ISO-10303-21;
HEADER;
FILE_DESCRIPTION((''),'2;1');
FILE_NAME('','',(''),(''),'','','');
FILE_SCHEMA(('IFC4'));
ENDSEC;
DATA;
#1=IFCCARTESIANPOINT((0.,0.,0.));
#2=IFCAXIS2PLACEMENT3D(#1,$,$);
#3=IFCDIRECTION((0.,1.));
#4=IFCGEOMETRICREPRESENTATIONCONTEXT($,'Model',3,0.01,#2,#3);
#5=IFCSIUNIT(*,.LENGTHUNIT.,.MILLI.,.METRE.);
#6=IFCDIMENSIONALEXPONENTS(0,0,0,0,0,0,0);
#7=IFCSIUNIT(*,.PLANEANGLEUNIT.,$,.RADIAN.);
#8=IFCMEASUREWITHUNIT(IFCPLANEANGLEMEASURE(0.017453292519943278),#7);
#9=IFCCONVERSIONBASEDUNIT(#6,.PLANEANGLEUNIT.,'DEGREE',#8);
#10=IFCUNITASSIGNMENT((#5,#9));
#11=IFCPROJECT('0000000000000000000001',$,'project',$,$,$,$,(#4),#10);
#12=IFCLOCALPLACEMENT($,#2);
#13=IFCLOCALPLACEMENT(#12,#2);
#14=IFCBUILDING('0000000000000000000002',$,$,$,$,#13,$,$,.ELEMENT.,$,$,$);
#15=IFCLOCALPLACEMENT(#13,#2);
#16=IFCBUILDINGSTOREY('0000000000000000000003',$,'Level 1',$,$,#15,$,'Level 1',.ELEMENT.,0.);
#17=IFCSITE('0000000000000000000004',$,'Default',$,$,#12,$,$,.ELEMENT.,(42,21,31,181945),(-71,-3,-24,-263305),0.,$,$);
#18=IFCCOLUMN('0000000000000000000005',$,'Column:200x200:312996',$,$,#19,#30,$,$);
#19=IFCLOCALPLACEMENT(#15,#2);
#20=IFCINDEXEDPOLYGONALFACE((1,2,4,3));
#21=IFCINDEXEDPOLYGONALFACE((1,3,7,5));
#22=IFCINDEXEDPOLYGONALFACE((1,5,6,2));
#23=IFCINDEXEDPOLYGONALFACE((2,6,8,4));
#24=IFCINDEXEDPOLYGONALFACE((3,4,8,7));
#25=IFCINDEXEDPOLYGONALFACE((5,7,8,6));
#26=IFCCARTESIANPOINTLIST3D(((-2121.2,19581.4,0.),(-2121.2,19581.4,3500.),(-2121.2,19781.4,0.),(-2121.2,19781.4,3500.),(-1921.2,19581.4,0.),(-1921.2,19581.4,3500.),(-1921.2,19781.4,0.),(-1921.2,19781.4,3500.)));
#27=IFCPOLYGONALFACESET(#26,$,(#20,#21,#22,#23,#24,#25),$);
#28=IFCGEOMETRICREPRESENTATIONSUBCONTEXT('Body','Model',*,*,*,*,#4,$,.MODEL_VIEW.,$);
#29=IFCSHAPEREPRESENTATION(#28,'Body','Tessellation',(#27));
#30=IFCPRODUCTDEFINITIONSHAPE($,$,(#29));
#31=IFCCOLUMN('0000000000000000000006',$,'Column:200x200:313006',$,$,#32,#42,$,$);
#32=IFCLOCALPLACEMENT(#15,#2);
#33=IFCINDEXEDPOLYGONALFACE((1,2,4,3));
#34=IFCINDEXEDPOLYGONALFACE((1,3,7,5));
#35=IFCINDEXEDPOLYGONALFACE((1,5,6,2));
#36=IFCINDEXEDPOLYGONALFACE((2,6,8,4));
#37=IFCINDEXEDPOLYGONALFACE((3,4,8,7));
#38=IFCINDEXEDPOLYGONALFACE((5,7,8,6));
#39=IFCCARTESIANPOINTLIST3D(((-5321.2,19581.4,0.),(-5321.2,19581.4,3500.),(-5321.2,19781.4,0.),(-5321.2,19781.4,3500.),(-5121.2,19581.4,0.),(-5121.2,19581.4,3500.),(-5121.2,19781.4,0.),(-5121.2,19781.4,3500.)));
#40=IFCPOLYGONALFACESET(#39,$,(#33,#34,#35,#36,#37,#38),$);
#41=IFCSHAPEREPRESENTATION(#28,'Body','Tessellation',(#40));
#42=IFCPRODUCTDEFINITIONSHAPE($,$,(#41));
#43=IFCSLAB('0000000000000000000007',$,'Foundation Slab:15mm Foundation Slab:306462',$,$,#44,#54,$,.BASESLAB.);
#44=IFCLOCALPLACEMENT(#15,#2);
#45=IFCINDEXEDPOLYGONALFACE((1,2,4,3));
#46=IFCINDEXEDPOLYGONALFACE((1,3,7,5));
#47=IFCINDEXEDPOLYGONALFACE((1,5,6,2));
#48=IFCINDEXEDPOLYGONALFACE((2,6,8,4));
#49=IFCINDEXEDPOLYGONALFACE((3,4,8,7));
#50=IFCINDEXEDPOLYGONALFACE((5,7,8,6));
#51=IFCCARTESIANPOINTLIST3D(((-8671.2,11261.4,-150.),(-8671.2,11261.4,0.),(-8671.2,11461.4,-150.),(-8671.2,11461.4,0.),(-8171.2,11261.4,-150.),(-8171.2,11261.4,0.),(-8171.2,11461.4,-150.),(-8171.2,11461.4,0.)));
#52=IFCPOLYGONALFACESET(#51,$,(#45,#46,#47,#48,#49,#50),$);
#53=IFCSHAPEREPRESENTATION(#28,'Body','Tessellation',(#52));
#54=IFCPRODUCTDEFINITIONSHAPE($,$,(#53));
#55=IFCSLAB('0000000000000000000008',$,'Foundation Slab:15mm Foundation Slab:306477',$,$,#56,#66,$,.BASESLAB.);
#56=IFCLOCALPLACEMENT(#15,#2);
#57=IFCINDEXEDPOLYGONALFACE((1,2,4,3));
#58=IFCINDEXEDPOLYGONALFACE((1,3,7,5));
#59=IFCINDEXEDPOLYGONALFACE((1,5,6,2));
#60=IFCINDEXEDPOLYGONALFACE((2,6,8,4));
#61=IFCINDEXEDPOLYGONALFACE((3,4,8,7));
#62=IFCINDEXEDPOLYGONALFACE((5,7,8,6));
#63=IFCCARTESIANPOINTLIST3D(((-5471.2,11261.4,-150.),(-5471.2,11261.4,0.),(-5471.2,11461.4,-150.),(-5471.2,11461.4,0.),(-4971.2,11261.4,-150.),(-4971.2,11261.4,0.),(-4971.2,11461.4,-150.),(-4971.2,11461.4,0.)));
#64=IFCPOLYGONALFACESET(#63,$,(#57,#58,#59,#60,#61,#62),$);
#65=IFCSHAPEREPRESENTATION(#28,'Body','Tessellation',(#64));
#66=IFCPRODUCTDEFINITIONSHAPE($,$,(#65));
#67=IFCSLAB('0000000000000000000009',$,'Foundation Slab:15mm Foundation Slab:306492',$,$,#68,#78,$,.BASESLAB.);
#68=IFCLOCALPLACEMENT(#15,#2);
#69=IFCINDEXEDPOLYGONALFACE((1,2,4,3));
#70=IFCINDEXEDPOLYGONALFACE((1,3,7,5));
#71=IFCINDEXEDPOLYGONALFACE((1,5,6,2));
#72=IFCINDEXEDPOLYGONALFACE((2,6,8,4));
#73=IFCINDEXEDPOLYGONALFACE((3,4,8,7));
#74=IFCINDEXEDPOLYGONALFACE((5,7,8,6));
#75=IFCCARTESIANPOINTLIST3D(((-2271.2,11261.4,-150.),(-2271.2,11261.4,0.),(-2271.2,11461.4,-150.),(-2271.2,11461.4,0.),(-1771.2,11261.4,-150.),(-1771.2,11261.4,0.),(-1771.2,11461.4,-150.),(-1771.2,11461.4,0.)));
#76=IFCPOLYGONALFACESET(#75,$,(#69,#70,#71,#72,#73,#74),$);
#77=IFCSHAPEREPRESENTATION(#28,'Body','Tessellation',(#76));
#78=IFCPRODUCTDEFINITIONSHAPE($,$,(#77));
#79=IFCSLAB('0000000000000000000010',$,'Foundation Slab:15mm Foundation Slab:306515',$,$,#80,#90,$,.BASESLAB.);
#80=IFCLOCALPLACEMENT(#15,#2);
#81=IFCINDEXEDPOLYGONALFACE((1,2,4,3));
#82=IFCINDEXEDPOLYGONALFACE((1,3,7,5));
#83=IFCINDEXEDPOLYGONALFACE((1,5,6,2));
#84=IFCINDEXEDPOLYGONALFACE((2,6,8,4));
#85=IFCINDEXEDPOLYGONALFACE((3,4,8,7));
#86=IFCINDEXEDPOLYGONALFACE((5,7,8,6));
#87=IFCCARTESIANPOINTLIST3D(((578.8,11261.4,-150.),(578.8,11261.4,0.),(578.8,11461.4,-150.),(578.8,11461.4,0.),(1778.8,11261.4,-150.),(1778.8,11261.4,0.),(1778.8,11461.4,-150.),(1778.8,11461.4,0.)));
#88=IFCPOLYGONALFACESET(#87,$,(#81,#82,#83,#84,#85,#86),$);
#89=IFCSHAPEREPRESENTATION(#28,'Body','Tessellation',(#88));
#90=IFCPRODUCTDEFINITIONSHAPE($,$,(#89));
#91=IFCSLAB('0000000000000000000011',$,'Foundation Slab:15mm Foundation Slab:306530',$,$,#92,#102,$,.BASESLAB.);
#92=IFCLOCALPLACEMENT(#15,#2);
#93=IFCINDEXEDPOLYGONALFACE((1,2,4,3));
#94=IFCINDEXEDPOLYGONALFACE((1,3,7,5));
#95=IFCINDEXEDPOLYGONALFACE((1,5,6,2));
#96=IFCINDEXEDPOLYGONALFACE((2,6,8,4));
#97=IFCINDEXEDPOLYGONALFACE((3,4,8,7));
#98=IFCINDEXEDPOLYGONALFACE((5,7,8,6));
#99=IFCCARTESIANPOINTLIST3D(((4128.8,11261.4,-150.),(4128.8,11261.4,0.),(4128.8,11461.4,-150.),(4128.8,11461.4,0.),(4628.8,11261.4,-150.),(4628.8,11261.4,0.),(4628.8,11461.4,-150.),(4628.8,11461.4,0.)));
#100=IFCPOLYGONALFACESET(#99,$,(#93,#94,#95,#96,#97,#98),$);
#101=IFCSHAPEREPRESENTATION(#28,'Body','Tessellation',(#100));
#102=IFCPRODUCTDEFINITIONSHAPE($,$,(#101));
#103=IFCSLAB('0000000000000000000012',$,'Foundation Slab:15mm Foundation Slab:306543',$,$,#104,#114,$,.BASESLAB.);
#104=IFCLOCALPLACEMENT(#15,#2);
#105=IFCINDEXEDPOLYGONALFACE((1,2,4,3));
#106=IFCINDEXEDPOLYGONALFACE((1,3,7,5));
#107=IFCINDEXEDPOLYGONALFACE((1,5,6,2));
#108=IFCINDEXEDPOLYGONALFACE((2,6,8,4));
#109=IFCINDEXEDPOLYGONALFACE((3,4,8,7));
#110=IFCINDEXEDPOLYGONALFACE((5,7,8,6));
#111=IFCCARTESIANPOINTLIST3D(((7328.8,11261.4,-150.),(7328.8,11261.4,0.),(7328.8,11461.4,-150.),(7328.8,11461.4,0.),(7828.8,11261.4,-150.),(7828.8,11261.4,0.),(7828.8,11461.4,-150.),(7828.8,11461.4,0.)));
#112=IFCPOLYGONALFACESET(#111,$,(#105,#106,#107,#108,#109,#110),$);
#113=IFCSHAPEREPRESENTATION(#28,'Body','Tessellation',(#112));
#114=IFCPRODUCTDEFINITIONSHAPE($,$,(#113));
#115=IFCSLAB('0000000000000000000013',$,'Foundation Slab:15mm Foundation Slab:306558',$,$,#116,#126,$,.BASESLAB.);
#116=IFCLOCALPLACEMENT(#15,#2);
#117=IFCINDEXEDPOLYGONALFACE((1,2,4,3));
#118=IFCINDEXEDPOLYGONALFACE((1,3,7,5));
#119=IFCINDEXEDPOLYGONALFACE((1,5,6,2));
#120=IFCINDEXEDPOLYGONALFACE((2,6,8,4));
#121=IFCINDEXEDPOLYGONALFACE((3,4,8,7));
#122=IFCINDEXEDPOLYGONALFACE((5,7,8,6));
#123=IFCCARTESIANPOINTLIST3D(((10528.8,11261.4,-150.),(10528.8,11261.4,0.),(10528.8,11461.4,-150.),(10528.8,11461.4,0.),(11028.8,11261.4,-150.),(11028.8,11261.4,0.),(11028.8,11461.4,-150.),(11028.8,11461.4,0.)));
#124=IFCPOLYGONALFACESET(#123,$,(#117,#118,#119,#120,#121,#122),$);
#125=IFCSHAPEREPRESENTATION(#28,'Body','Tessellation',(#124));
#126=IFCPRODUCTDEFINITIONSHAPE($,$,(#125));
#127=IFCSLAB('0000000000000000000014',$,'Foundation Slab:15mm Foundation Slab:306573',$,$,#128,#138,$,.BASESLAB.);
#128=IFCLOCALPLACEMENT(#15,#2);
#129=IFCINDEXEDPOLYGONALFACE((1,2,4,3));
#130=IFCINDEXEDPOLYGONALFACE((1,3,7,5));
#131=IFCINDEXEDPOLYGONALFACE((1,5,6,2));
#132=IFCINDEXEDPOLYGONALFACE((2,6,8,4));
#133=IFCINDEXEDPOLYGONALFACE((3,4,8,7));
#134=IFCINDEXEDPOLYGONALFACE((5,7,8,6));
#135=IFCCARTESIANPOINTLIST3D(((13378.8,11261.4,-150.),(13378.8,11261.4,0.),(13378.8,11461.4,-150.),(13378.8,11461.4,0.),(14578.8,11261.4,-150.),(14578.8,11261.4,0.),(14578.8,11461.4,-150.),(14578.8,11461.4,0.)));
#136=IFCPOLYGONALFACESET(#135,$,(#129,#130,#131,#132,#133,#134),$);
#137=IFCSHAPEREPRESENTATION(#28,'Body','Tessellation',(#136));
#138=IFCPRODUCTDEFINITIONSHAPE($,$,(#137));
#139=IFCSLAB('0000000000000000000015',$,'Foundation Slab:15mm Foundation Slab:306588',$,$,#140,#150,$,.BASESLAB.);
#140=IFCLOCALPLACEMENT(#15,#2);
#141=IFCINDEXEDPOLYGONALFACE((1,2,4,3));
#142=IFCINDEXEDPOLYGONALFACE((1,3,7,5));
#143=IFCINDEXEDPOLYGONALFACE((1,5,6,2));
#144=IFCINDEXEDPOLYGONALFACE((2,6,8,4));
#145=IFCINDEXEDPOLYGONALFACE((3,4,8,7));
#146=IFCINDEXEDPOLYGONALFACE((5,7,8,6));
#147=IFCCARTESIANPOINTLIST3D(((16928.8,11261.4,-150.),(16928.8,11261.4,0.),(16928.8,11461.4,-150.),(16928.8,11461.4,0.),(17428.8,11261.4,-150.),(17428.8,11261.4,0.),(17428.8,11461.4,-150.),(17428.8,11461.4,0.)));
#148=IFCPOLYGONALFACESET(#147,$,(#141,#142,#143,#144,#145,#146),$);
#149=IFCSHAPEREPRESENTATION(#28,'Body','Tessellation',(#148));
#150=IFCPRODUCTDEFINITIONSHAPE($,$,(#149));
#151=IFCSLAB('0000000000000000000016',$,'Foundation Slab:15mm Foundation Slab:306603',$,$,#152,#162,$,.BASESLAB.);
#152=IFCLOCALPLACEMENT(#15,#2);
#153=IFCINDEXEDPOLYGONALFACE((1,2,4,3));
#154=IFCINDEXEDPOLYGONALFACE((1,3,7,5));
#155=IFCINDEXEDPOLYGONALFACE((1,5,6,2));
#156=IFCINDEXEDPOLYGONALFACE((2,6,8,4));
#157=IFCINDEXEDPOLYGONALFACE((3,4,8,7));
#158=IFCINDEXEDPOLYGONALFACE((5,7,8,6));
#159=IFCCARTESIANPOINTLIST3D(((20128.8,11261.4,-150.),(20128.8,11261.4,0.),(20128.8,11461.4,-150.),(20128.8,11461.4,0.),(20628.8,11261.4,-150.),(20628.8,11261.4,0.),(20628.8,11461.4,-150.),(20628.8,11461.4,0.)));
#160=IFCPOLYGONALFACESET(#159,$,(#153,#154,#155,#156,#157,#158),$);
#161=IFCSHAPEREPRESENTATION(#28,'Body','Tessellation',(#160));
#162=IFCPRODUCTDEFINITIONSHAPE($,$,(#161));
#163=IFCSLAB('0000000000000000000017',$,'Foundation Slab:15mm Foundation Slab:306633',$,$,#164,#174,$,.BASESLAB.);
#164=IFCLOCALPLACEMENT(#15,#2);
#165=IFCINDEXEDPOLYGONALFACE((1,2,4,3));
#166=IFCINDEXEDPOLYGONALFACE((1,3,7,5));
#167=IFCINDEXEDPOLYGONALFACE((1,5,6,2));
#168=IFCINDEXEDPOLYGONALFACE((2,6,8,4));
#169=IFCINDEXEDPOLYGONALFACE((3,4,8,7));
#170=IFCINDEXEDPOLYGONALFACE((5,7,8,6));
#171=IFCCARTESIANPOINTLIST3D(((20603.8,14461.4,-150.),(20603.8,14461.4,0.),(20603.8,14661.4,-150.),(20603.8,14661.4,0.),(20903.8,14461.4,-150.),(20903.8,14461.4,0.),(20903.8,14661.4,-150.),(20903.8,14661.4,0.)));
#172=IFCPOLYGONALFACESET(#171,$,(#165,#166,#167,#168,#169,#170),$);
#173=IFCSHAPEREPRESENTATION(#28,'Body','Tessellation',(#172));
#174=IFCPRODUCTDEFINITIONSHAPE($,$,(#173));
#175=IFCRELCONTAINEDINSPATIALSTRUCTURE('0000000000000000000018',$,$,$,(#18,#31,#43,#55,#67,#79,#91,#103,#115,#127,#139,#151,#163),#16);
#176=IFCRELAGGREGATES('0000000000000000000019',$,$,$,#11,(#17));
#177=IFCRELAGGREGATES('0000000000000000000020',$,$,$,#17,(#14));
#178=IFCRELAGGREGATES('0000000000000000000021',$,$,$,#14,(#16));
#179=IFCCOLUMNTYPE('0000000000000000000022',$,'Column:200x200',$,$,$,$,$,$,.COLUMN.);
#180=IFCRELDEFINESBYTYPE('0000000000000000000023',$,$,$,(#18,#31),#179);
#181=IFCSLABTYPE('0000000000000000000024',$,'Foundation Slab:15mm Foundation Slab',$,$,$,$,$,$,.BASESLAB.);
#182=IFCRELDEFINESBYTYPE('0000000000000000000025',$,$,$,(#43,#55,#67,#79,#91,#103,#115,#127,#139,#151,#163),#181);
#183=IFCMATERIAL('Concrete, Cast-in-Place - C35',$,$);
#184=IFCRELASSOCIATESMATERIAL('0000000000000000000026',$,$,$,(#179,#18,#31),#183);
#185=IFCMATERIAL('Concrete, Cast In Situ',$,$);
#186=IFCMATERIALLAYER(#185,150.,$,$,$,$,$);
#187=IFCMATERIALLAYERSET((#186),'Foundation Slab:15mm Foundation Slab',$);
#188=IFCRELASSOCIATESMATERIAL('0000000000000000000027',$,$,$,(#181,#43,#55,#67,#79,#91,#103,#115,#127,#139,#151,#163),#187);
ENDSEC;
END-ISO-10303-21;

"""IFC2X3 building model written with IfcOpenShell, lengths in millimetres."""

from ifc_helpers import new_model, entity, si_unit, converted_unit, direction, frame, frame_2d, origin, place, context, subcontext, project, spatial, rectangle, extrude, source, transform, mapped, material, layer, layer_set, layer_usage, type_object, type_shapes, element, save


model = new_model("IFC2X3")

# Units and contexts
model_context = context("Model", 3, precision=0.01, world=origin(), true_north=direction((0.0, 1.0)))
body_context = subcontext(model_context, "Body", "Model", "MODEL_VIEW")
ifc_project = project(units=[si_unit("LENGTHUNIT", "METRE", prefix="MILLI"), converted_unit("PLANEANGLEUNIT", "DEGREE", entity("IfcPlaneAngleMeasure", 0.017453292519943278), si_unit("PLANEANGLEUNIT", "RADIAN"), dimensions=[0, 0, 0, 0, 0, 0, 0])], contexts=[model_context])

# Site, building, storey
site_placement = place(None, origin())
site = spatial("IfcSite", under=ifc_project, at=site_placement, Name="Default", CompositionType="ELEMENT", RefLatitude=(42, 21, 31, 181945), RefLongitude=(-71, -3, -24, -263305), RefElevation=0.0)
building_placement = place(site_placement, origin())
building = spatial("IfcBuilding", under=site, at=building_placement, CompositionType="ELEMENT")
storey_placement = place(building_placement, origin())
storey = spatial("IfcBuildingStorey", under=building, at=storey_placement, Name="Level 1", LongName="Level 1", CompositionType="ELEMENT", Elevation=0.0)

# Columns
ifc_material_1 = material(Name="Concrete, Cast-in-Place - C35")
column_type_1 = type_object("IfcColumnType", Name="Column:200x200", PredefinedType="COLUMN", material=ifc_material_1)
shared_shape_1 = source(origin(), body_context, "Body", "SweptSolid", [
    extrude(rectangle(XDim=200.0, YDim=200.0, at=frame_2d((0.0, 0.0), x_axis=(1.0, 0.0))), frame((0.0, 0.0, 0.0), z_axis=(0.0, 0.0, 1.0), x_axis=(-1.0, 0.0, 0.0)), (0.0, 0.0, 1.0), 3500.0),
])
type_shapes(column_type_1, [shared_shape_1])
for number, where, name in (
    (1, (-2021.2, 19681.4, 0.0), "Column:200x200:312996"),
    (2, (-5221.2, 19681.4, 0.0), "Column:200x200:313006"),
):
    element("IfcColumn", number, at=place(storey_placement, frame(where)), inside=storey, type_object=column_type_1, material=ifc_material_1, Name=name, context=body_context, shape_type="MappedRepresentation", body=[
        mapped(shared_shape_1, transform((0.0, 0.0, 0.0), scale=1.0)),
    ])

# Slabs
ifc_material_2 = material(Name="Concrete, Cast In Situ")
ifc_layer_1 = layer(ifc_material_2, 150.0)
ifc_layer_set_1 = layer_set([ifc_layer_1], Name="Foundation Slab:15mm Foundation Slab")
ifc_layer_usage_1 = layer_usage(ifc_layer_set_1, "AXIS3", "POSITIVE", 0.0)
slab_type = type_object("IfcSlabType", Name="Foundation Slab:15mm Foundation Slab", PredefinedType="BASESLAB", material=ifc_layer_set_1)
slab_1_placement = place(storey_placement, origin())
element("IfcSlab", 3, at=slab_1_placement, inside=storey, type_object=slab_type, material=ifc_layer_usage_1, Name="Foundation Slab:15mm Foundation Slab:306462", PredefinedType="BASESLAB", context=body_context, shape_type="SweptSolid", body=[
    extrude(rectangle(XDim=200.0, YDim=500.0, at=frame_2d((0.0, 0.0), x_axis=(1.0, 0.0))), frame((-8421.2, 11361.4, 0.0), z_axis=(0.0, 0.0, -1.0), x_axis=(0.0, 1.0, 0.0)), (0.0, 0.0, 1.0), 150.0),
])
ifc_layer_usage_2 = layer_usage(ifc_layer_set_1, "AXIS3", "POSITIVE", 0.0)
slab_2_placement = place(storey_placement, origin())
element("IfcSlab", 4, at=slab_2_placement, inside=storey, type_object=slab_type, material=ifc_layer_usage_2, Name="Foundation Slab:15mm Foundation Slab:306477", PredefinedType="BASESLAB", context=body_context, shape_type="SweptSolid", body=[
    extrude(rectangle(XDim=200.0, YDim=500.0, at=frame_2d((0.0, 0.0), x_axis=(1.0, 0.0))), frame((-5221.2, 11361.4, 0.0), z_axis=(0.0, 0.0, -1.0), x_axis=(0.0, 1.0, 0.0)), (0.0, 0.0, 1.0), 150.0),
])
ifc_layer_usage_3 = layer_usage(ifc_layer_set_1, "AXIS3", "POSITIVE", 0.0)
slab_3_placement = place(storey_placement, origin())
element("IfcSlab", 5, at=slab_3_placement, inside=storey, type_object=slab_type, material=ifc_layer_usage_3, Name="Foundation Slab:15mm Foundation Slab:306492", PredefinedType="BASESLAB", context=body_context, shape_type="SweptSolid", body=[
    extrude(rectangle(XDim=200.0, YDim=500.0, at=frame_2d((0.0, 0.0), x_axis=(1.0, 0.0))), frame((-2021.2, 11361.4, 0.0), z_axis=(0.0, 0.0, -1.0), x_axis=(0.0, 1.0, 0.0)), (0.0, 0.0, 1.0), 150.0),
])
ifc_layer_usage_4 = layer_usage(ifc_layer_set_1, "AXIS3", "POSITIVE", 0.0)
slab_4_placement = place(storey_placement, origin())
element("IfcSlab", 6, at=slab_4_placement, inside=storey, type_object=slab_type, material=ifc_layer_usage_4, Name="Foundation Slab:15mm Foundation Slab:306515", PredefinedType="BASESLAB", context=body_context, shape_type="SweptSolid", body=[
    extrude(rectangle(XDim=200.0, YDim=1200.0, at=frame_2d((0.0, 0.0), x_axis=(1.0, 0.0))), frame((1178.8, 11361.4, 0.0), z_axis=(0.0, 0.0, -1.0), x_axis=(0.0, 1.0, 0.0)), (0.0, 0.0, 1.0), 150.0),
])
ifc_layer_usage_5 = layer_usage(ifc_layer_set_1, "AXIS3", "POSITIVE", 0.0)
slab_5_placement = place(storey_placement, origin())
element("IfcSlab", 7, at=slab_5_placement, inside=storey, type_object=slab_type, material=ifc_layer_usage_5, Name="Foundation Slab:15mm Foundation Slab:306530", PredefinedType="BASESLAB", context=body_context, shape_type="SweptSolid", body=[
    extrude(rectangle(XDim=200.0, YDim=500.0, at=frame_2d((0.0, 0.0), x_axis=(1.0, 0.0))), frame((4378.8, 11361.4, 0.0), z_axis=(0.0, 0.0, -1.0), x_axis=(0.0, 1.0, 0.0)), (0.0, 0.0, 1.0), 150.0),
])
ifc_layer_usage_6 = layer_usage(ifc_layer_set_1, "AXIS3", "POSITIVE", 0.0)
slab_6_placement = place(storey_placement, origin())
element("IfcSlab", 8, at=slab_6_placement, inside=storey, type_object=slab_type, material=ifc_layer_usage_6, Name="Foundation Slab:15mm Foundation Slab:306543", PredefinedType="BASESLAB", context=body_context, shape_type="SweptSolid", body=[
    extrude(rectangle(XDim=200.0, YDim=500.0, at=frame_2d((0.0, 0.0), x_axis=(1.0, 0.0))), frame((7578.8, 11361.4, 0.0), z_axis=(0.0, 0.0, -1.0), x_axis=(0.0, 1.0, 0.0)), (0.0, 0.0, 1.0), 150.0),
])
ifc_layer_usage_7 = layer_usage(ifc_layer_set_1, "AXIS3", "POSITIVE", 0.0)
slab_7_placement = place(storey_placement, origin())
element("IfcSlab", 9, at=slab_7_placement, inside=storey, type_object=slab_type, material=ifc_layer_usage_7, Name="Foundation Slab:15mm Foundation Slab:306558", PredefinedType="BASESLAB", context=body_context, shape_type="SweptSolid", body=[
    extrude(rectangle(XDim=200.0, YDim=500.0, at=frame_2d((0.0, 0.0), x_axis=(1.0, 0.0))), frame((10778.8, 11361.4, 0.0), z_axis=(0.0, 0.0, -1.0), x_axis=(0.0, 1.0, 0.0)), (0.0, 0.0, 1.0), 150.0),
])
ifc_layer_usage_8 = layer_usage(ifc_layer_set_1, "AXIS3", "POSITIVE", 0.0)
slab_8_placement = place(storey_placement, origin())
element("IfcSlab", 10, at=slab_8_placement, inside=storey, type_object=slab_type, material=ifc_layer_usage_8, Name="Foundation Slab:15mm Foundation Slab:306573", PredefinedType="BASESLAB", context=body_context, shape_type="SweptSolid", body=[
    extrude(rectangle(XDim=200.0, YDim=1200.0, at=frame_2d((0.0, 0.0), x_axis=(1.0, 0.0))), frame((13978.8, 11361.4, 0.0), z_axis=(0.0, 0.0, -1.0), x_axis=(0.0, 1.0, 0.0)), (0.0, 0.0, 1.0), 150.0),
])
ifc_layer_usage_9 = layer_usage(ifc_layer_set_1, "AXIS3", "POSITIVE", 0.0)
slab_9_placement = place(storey_placement, origin())
element("IfcSlab", 11, at=slab_9_placement, inside=storey, type_object=slab_type, material=ifc_layer_usage_9, Name="Foundation Slab:15mm Foundation Slab:306588", PredefinedType="BASESLAB", context=body_context, shape_type="SweptSolid", body=[
    extrude(rectangle(XDim=200.0, YDim=500.0, at=frame_2d((0.0, 0.0), x_axis=(1.0, 0.0))), frame((17178.8, 11361.4, 0.0), z_axis=(0.0, 0.0, -1.0), x_axis=(0.0, 1.0, 0.0)), (0.0, 0.0, 1.0), 150.0),
])
ifc_layer_usage_10 = layer_usage(ifc_layer_set_1, "AXIS3", "POSITIVE", 0.0)
slab_10_placement = place(storey_placement, origin())
element("IfcSlab", 12, at=slab_10_placement, inside=storey, type_object=slab_type, material=ifc_layer_usage_10, Name="Foundation Slab:15mm Foundation Slab:306603", PredefinedType="BASESLAB", context=body_context, shape_type="SweptSolid", body=[
    extrude(rectangle(XDim=200.0, YDim=500.0, at=frame_2d((0.0, 0.0), x_axis=(1.0, 0.0))), frame((20378.8, 11361.4, 0.0), z_axis=(0.0, 0.0, -1.0), x_axis=(0.0, 1.0, 0.0)), (0.0, 0.0, 1.0), 150.0),
])
ifc_layer_usage_11 = layer_usage(ifc_layer_set_1, "AXIS3", "POSITIVE", 0.0)
slab_11_placement = place(storey_placement, origin())
element("IfcSlab", 13, at=slab_11_placement, inside=storey, type_object=slab_type, material=ifc_layer_usage_11, Name="Foundation Slab:15mm Foundation Slab:306633", PredefinedType="BASESLAB", context=body_context, shape_type="SweptSolid", body=[
    extrude(rectangle(XDim=200.0, YDim=300.0, at=frame_2d((0.0, 0.0), x_axis=(1.0, 0.0))), frame((20753.8, 14561.4, 0.0), z_axis=(0.0, 0.0, -1.0), x_axis=(0.0, 1.0, 0.0)), (0.0, 0.0, 1.0), 150.0),
])

save(model, "model.ifc")
